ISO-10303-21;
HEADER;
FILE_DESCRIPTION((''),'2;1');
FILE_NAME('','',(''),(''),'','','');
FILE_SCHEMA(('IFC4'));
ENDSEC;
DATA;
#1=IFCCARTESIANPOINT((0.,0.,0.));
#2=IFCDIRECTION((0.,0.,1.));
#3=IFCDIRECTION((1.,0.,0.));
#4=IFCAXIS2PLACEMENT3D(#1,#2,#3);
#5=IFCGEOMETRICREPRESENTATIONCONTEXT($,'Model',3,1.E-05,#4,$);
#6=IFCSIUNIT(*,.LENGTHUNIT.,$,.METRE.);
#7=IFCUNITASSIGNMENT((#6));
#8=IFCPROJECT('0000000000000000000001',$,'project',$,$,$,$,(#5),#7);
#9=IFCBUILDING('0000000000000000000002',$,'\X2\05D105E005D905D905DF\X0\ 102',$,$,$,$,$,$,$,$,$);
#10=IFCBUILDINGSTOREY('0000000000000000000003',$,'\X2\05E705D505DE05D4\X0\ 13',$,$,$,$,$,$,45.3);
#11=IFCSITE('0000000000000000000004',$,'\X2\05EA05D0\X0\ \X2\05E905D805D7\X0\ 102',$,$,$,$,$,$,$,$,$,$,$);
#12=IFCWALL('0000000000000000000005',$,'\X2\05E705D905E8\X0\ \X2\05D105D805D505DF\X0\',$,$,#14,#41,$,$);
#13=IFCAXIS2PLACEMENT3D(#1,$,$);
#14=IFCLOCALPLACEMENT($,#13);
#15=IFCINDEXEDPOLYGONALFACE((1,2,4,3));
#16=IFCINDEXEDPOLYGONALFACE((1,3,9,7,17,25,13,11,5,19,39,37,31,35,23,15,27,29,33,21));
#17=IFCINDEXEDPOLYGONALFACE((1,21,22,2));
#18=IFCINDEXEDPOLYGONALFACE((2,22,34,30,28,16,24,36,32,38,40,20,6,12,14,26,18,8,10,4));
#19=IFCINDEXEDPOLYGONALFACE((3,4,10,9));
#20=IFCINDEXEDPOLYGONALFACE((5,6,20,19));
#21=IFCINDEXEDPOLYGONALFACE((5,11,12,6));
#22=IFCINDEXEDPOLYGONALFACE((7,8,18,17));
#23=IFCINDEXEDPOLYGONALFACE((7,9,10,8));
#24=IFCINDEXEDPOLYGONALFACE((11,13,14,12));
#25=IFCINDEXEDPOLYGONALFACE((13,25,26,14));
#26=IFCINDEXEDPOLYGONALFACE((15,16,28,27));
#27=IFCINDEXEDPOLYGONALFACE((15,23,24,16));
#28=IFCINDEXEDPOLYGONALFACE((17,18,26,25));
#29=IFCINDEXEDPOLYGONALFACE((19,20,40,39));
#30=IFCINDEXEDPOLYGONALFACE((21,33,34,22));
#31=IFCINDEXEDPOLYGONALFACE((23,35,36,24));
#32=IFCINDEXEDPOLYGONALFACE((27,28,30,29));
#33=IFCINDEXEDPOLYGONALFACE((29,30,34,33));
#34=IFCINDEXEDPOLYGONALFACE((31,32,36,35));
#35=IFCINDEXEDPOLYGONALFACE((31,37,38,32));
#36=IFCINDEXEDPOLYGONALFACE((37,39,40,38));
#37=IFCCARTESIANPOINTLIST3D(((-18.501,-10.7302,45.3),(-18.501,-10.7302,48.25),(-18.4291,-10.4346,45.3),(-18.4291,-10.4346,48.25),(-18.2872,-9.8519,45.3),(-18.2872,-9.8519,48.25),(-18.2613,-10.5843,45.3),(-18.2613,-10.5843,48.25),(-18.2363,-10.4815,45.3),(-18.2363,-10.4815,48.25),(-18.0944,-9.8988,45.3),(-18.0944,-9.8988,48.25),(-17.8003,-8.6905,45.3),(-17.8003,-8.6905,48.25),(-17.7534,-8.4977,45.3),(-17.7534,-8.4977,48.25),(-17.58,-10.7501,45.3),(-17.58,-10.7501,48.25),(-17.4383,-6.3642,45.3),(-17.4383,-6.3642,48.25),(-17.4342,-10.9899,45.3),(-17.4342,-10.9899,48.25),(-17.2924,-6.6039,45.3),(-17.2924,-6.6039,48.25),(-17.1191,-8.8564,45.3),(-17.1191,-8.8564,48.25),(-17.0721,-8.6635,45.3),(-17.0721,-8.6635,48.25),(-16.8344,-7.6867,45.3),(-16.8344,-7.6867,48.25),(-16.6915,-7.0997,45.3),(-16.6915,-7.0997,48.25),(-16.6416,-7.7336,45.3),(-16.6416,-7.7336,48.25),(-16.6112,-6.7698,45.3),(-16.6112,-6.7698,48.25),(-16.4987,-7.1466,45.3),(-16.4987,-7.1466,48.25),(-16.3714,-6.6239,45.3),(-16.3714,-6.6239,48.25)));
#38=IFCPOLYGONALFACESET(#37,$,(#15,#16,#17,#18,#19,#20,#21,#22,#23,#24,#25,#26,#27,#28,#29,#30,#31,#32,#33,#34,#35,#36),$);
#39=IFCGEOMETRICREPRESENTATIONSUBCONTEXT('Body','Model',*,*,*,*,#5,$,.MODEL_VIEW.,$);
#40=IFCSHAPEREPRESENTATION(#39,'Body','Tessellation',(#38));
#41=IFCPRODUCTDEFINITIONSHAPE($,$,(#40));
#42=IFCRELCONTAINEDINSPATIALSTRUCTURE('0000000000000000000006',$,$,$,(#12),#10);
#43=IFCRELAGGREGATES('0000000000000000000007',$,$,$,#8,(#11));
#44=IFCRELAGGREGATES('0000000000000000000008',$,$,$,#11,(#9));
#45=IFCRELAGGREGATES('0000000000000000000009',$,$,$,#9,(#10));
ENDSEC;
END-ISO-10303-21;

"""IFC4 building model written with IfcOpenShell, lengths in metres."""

from ifc_helpers import new_model, si_unit, frame, origin_with_axes, context, subcontext, project, spatial, polyline, outline, extrude, element, save


model = new_model("IFC4")

# Units and contexts
model_context = context("Model", 3, precision=1e-05, world=origin_with_axes())
body_context = subcontext(model_context, "Body", "Model", "MODEL_VIEW")
ifc_project = project(units=[si_unit("LENGTHUNIT", "METRE")], contexts=[model_context])

# Site, building, storey
site = spatial("IfcSite", under=ifc_project, Name="תא שטח 102")
building = spatial("IfcBuilding", under=site, Name="בניין 102")
storey = spatial("IfcBuildingStorey", under=building, Name="קומה 13", Elevation=45.3)

# Wall
element("IfcWall", 1, inside=storey, Name="קיר בטון", context=body_context, shape_type="SweptSolid", body=[
    extrude(outline(polyline([(-18.4291, -10.4346), (-18.501, -10.7302), (-17.4342, -10.9899), (-16.6416, -7.7336), (-16.8344, -7.6867), (-17.0721, -8.6635), (-17.7534, -8.4977), (-17.2924, -6.6039), (-16.6112, -6.7698), (-16.6915, -7.0997), (-16.4987, -7.1466), (-16.3714, -6.6239), (-17.4383, -6.3642), (-18.2872, -9.8519), (-18.0944, -9.8988), (-17.8003, -8.6905), (-17.1191, -8.8564), (-17.58, -10.7501), (-18.2613, -10.5843), (-18.2363, -10.4815), (-18.4291, -10.4346)])), frame((0.0, 0.0, 45.3)), (0.0, 0.0, 1.0), 2.95),
])

save(model, "model.ifc")
